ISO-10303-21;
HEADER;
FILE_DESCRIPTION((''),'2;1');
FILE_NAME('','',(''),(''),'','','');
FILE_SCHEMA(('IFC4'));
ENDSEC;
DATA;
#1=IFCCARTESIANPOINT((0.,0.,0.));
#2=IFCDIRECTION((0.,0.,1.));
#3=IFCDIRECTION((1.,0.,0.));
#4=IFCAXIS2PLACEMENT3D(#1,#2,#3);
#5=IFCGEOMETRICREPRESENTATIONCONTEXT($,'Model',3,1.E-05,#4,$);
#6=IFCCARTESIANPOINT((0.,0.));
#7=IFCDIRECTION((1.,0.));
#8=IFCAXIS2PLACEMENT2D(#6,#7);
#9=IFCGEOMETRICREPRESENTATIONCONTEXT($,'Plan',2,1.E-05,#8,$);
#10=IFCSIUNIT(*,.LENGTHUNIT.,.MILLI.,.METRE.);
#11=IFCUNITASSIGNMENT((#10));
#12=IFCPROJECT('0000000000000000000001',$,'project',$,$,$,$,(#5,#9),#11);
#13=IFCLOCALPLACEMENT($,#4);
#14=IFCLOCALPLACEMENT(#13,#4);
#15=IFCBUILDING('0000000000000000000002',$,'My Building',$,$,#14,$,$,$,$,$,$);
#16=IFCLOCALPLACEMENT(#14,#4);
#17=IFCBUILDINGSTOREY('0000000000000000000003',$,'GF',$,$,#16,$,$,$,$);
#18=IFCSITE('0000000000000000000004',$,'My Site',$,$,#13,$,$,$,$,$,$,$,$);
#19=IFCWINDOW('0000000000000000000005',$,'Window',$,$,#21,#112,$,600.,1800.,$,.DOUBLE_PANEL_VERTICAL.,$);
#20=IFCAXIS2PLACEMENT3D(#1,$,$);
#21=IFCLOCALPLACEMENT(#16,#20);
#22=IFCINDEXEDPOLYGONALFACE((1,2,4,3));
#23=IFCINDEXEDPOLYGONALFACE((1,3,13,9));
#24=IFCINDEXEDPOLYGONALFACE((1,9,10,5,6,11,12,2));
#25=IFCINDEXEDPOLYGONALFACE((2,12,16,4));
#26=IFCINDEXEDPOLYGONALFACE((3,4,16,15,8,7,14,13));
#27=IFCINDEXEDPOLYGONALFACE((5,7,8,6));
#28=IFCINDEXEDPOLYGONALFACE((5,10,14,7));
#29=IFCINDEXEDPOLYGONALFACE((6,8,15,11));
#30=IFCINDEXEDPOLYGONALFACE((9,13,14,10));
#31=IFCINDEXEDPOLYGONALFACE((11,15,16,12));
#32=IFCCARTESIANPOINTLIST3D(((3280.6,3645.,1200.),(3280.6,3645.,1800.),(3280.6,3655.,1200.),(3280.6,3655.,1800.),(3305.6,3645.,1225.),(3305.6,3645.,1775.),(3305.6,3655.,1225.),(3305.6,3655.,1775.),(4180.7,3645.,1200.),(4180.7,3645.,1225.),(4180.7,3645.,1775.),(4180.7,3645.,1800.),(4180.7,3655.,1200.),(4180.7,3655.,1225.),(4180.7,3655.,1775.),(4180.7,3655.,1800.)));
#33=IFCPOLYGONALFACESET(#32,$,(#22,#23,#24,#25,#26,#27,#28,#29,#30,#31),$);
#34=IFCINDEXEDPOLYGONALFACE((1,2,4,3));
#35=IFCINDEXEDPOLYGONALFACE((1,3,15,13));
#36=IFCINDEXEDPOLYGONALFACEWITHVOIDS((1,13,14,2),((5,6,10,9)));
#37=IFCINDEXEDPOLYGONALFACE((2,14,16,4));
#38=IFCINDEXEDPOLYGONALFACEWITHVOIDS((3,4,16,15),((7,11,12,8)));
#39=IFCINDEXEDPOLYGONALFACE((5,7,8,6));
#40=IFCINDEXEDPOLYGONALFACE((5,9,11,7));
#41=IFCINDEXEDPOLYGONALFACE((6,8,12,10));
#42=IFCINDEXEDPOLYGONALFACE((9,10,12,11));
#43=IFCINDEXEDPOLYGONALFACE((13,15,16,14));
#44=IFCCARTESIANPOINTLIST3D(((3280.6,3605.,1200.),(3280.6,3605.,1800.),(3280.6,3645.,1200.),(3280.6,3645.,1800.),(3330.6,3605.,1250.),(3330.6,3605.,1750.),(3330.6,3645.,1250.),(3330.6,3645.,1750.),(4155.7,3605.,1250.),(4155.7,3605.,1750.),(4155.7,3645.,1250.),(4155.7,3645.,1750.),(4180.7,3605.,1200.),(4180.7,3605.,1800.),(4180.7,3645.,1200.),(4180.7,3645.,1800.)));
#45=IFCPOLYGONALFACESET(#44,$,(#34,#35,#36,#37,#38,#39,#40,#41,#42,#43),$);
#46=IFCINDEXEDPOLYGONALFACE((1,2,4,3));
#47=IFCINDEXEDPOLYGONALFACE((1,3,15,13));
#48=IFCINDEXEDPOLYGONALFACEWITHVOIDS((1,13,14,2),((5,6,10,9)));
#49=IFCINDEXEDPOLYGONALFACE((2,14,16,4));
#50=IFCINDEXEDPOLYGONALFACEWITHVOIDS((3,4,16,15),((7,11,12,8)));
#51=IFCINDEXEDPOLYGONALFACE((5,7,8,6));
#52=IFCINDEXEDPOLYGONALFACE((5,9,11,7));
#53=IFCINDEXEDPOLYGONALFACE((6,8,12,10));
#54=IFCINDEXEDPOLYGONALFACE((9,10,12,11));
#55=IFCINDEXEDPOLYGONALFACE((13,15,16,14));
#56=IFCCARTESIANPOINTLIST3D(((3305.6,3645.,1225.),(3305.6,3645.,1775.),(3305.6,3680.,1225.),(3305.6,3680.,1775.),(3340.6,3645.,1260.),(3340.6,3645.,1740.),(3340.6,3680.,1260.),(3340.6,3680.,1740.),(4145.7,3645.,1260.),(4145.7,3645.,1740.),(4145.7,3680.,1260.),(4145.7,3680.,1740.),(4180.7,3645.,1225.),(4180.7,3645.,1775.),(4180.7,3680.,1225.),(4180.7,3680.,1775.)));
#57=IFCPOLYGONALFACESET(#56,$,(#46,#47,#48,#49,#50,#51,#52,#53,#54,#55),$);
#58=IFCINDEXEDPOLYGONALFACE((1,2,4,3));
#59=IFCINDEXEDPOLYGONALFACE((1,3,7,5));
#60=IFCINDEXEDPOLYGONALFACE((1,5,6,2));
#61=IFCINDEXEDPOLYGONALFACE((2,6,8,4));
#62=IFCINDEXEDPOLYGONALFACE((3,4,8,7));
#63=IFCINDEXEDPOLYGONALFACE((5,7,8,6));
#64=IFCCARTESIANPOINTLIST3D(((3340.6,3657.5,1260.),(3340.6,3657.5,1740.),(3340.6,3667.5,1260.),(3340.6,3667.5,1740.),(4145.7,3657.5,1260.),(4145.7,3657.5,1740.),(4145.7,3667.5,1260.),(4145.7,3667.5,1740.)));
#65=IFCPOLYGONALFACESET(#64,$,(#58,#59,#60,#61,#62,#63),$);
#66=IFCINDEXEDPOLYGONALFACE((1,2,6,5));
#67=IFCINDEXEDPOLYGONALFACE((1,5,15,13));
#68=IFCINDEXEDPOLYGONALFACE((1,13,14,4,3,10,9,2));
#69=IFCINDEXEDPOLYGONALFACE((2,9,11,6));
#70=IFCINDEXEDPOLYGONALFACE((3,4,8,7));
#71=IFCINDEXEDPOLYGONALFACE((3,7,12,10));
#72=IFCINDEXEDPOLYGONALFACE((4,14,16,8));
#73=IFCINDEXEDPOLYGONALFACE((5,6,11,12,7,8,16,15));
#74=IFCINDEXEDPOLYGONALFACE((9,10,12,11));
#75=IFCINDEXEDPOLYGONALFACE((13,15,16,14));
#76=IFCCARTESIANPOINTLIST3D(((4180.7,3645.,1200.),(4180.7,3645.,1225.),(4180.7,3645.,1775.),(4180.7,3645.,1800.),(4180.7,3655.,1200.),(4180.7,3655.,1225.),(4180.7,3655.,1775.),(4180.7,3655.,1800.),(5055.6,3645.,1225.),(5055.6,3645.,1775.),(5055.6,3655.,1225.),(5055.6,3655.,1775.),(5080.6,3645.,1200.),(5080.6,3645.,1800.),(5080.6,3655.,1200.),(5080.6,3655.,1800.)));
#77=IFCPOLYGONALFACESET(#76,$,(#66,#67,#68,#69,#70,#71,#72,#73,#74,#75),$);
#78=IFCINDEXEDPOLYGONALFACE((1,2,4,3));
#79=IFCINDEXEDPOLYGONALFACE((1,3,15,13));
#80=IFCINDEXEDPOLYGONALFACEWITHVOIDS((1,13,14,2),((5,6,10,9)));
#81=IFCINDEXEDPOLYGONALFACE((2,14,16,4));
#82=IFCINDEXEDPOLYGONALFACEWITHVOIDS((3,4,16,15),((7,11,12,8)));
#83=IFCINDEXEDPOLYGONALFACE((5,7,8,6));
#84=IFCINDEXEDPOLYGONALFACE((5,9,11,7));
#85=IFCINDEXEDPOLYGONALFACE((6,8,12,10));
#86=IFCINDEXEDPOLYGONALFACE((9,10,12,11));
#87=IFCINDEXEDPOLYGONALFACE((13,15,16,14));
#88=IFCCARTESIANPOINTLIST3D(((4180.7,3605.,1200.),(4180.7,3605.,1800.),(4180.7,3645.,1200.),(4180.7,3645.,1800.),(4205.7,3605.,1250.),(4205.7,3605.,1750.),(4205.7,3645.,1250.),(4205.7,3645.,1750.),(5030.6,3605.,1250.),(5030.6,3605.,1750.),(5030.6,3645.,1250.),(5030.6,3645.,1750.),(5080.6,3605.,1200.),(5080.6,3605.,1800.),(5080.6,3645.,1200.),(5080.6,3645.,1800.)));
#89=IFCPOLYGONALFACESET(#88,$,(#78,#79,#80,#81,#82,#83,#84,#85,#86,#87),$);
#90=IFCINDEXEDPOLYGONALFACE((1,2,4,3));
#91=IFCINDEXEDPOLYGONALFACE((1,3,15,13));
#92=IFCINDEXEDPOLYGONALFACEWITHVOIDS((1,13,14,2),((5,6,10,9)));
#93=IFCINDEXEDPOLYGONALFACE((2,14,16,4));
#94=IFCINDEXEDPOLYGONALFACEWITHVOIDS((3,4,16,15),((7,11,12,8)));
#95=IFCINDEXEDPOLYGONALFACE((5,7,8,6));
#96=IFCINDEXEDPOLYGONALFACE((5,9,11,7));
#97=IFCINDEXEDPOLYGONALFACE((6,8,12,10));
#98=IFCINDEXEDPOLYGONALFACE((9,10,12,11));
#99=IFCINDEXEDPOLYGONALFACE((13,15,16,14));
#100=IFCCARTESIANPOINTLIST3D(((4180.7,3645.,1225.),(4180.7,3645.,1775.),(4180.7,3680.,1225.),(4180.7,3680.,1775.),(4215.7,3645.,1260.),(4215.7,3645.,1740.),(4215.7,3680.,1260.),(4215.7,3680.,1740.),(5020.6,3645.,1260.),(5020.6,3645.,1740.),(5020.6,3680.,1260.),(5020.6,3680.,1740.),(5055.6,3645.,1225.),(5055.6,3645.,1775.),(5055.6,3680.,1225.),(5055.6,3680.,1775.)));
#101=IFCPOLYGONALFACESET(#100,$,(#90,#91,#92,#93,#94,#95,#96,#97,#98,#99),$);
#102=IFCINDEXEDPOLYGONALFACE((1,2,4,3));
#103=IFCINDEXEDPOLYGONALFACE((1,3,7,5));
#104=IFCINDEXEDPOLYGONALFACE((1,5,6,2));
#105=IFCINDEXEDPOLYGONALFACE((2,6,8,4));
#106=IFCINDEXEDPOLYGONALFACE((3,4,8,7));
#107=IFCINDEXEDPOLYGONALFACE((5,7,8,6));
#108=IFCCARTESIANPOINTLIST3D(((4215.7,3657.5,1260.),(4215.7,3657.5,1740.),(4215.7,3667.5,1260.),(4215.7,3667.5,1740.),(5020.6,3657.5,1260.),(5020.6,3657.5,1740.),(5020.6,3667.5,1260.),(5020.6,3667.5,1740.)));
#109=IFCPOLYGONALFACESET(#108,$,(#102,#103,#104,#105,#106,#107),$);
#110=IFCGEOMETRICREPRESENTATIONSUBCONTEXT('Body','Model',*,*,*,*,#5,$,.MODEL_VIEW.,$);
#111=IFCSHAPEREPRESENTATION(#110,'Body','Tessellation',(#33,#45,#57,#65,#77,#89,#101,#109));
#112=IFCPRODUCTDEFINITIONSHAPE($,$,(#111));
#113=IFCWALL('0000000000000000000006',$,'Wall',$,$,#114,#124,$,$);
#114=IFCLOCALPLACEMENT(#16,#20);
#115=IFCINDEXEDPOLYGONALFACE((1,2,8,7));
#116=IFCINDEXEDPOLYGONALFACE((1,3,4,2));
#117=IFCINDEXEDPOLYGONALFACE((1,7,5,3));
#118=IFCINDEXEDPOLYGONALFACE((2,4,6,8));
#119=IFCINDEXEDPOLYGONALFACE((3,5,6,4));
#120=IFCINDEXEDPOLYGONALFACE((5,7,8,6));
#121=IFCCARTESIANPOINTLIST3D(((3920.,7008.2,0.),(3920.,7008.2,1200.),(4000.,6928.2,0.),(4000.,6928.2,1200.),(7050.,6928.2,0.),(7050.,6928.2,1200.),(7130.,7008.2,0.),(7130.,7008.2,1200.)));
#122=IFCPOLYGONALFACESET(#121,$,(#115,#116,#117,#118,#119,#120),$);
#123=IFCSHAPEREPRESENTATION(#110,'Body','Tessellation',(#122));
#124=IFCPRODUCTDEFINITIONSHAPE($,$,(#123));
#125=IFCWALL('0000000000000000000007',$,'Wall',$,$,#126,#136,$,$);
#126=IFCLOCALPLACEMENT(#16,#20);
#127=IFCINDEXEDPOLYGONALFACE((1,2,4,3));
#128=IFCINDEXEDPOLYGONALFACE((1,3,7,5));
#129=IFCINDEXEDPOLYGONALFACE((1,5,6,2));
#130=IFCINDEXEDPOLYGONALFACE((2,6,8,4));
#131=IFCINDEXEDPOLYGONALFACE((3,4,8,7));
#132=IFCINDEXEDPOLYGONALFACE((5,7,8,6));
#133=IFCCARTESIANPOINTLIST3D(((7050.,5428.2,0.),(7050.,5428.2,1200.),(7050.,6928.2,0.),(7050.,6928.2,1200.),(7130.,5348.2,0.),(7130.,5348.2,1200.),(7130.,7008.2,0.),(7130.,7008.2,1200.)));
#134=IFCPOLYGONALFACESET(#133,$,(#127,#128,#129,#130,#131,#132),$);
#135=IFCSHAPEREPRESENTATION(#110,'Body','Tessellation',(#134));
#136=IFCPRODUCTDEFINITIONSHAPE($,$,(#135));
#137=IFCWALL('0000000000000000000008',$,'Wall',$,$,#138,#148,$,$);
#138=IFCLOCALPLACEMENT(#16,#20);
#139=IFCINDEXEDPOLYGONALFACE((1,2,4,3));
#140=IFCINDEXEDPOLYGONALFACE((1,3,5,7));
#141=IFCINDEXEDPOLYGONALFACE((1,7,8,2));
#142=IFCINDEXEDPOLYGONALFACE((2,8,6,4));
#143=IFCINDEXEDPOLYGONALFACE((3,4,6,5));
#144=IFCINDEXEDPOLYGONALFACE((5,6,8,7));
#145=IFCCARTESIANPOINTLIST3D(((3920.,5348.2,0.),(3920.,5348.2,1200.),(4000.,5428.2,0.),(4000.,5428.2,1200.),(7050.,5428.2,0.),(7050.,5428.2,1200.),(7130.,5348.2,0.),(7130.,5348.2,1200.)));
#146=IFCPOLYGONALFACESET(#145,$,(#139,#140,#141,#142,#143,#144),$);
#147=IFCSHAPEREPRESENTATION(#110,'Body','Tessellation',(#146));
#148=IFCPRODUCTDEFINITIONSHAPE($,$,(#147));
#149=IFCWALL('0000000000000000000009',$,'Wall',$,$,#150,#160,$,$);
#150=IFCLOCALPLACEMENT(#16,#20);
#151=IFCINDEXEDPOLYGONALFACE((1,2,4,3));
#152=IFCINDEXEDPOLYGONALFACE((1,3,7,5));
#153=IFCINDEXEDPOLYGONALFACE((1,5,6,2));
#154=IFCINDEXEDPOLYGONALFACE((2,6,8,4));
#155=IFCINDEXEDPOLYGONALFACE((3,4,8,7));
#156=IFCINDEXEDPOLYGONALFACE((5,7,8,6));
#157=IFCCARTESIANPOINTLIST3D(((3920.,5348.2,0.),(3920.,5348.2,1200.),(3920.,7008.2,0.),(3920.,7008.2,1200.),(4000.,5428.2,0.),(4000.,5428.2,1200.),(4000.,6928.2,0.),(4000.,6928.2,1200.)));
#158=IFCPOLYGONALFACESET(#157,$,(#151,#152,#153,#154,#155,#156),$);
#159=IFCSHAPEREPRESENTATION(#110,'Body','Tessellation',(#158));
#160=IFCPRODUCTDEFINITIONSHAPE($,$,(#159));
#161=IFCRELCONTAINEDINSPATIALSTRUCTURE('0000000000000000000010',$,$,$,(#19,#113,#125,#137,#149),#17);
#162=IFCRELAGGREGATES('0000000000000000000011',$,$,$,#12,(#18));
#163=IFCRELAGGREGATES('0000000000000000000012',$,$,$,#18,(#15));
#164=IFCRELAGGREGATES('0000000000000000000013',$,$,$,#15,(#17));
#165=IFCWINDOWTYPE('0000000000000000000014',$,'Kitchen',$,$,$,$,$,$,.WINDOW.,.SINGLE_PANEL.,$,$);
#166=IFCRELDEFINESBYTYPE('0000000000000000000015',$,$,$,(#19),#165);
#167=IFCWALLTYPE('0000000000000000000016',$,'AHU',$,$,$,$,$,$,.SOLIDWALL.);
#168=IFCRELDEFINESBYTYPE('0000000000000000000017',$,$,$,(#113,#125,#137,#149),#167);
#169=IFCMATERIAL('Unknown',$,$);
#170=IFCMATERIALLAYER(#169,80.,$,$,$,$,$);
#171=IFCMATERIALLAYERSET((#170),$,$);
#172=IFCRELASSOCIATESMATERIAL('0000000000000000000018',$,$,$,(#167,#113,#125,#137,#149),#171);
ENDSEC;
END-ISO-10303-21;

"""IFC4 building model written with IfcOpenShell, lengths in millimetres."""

from ifc_helpers import new_model, entity, si_unit, frame, origin_with_axes, origin_2d_with_axis, place, context, subcontext, project, spatial, line, indexed_curve, outline, extrude, shape, source, transform, mapped, material, layer, layer_set, layer_usage, type_object, type_shapes, element, save


model = new_model("IFC4")

# Units and contexts
model_context = context("Model", 3, precision=1e-05, world=origin_with_axes())
plan_context = context("Plan", 2, precision=1e-05, world=origin_2d_with_axis())
body_context_1 = subcontext(model_context, "Body", "Model", "MODEL_VIEW")
body_context_2 = subcontext(plan_context, "Body", "Plan", "PLAN_VIEW")
ifc_project = project(units=[si_unit("LENGTHUNIT", "METRE", prefix="MILLI")], contexts=[model_context, plan_context])

# Site, building, storey
site_placement = place(None, origin_with_axes())
site = spatial("IfcSite", under=ifc_project, at=site_placement, Name="My Site")
building_placement = place(site_placement, origin_with_axes())
building = spatial("IfcBuilding", under=site, at=building_placement, Name="My Building")
storey_placement = place(building_placement, origin_with_axes())
storey = spatial("IfcBuildingStorey", under=building, at=storey_placement, Name="GF")

# Shared definitions
ifc_material = material(Name="Unknown")

# Window
window_type_1 = type_object("IfcWindowType", Name="Kitchen", PartitioningType="SINGLE_PANEL", PredefinedType="WINDOW")
shared_shape_1 = source(origin_with_axes(), body_context_1, "Body", "SweptSolid", [
    extrude(outline(indexed_curve([(900.2, 0.0), (0.0, 0.0), (0.0, 600.0), (900.2, 600.0), (900.2, 575.0), (25.0, 575.0), (25.0, 25.0), (900.2, 25.0)], segments=[line(1, 2, 3, 4, 5, 6, 7, 8, 1)])), frame((0.0, 90.0, 0.0), z_axis=(0.0, -1.0, 0.0), x_axis=(1.0, 0.0, 0.0)), (0.0, 0.0, -1.0), 10.0),
    extrude(outline(indexed_curve([(0.0, 0.0), (900.2, 0.0), (900.2, 600.0), (0.0, 600.0)], segments=[line(1, 2, 3, 4, 1)]), holes=[indexed_curve([(50.0, 50.0), (875.2, 50.0), (875.2, 550.0), (50.0, 550.0)], segments=[line(1, 2, 3, 4, 1)])]), frame((0.0, 50.0, 0.0), z_axis=(0.0, -1.0, 0.0), x_axis=(1.0, 0.0, 0.0)), (0.0, 0.0, -1.0), 40.0),
    extrude(outline(indexed_curve([(0.0, 0.0), (875.2, 0.0), (875.2, 550.0), (0.0, 550.0)], segments=[line(1, 2, 3, 4, 1)]), holes=[indexed_curve([(35.0, 35.0), (840.2, 35.0), (840.2, 515.0), (35.0, 515.0)], segments=[line(1, 2, 3, 4, 1)])]), frame((25.0, 90.0, 25.0), z_axis=(0.0, -1.0, 0.0), x_axis=(1.0, 0.0, 0.0)), (0.0, 0.0, -1.0), 35.0),
    extrude(outline(indexed_curve([(35.0, 35.0), (840.2, 35.0), (840.2, 515.0), (35.0, 515.0)], segments=[line(1, 2, 3, 4, 1)])), frame((25.0, 102.5, 25.0), z_axis=(0.0, -1.0, 0.0), x_axis=(1.0, 0.0, 0.0)), (0.0, 0.0, -1.0), 10.0),
    extrude(outline(indexed_curve([(0.0, 600.0), (899.8, 600.0), (899.8, 0.0), (0.0, 0.0), (0.0, 25.0), (874.8, 25.0), (874.8, 575.0), (0.0, 575.0)], segments=[line(1, 2, 3, 4, 5, 6, 7, 8, 1)])), frame((900.2, 90.0, 0.0), z_axis=(0.0, -1.0, 0.0), x_axis=(1.0, 0.0, 0.0)), (0.0, 0.0, -1.0), 10.0),
    extrude(outline(indexed_curve([(0.0, 0.0), (899.8, 0.0), (899.8, 600.0), (0.0, 600.0)], segments=[line(1, 2, 3, 4, 1)]), holes=[indexed_curve([(25.0, 50.0), (849.8, 50.0), (849.8, 550.0), (25.0, 550.0)], segments=[line(1, 2, 3, 4, 1)])]), frame((900.2, 50.0, 0.0), z_axis=(0.0, -1.0, 0.0), x_axis=(1.0, 0.0, 0.0)), (0.0, 0.0, -1.0), 40.0),
    extrude(outline(indexed_curve([(0.0, 0.0), (874.8, 0.0), (874.8, 550.0), (0.0, 550.0)], segments=[line(1, 2, 3, 4, 1)]), holes=[indexed_curve([(35.0, 35.0), (839.8, 35.0), (839.8, 515.0), (35.0, 515.0)], segments=[line(1, 2, 3, 4, 1)])]), frame((900.2, 90.0, 25.0), z_axis=(0.0, -1.0, 0.0), x_axis=(1.0, 0.0, 0.0)), (0.0, 0.0, -1.0), 35.0),
    extrude(outline(indexed_curve([(35.0, 35.0), (839.8, 35.0), (839.8, 515.0), (35.0, 515.0)], segments=[line(1, 2, 3, 4, 1)])), frame((900.2, 102.5, 25.0), z_axis=(0.0, -1.0, 0.0), x_axis=(1.0, 0.0, 0.0)), (0.0, 0.0, -1.0), 10.0),
])
shared_shape_2 = source(origin_with_axes(), body_context_2, "Body", "Curve2D", [
    entity("IfcIndexedPolyCurve", entity("IfcCartesianPointList2D", [[50.0, 50.0], [875.2, 50.0]])),
    entity("IfcIndexedPolyCurve", entity("IfcCartesianPointList2D", [[0.0, 100.0], [25.0, 100.0], [25.0, 90.0], [50.0, 90.0], [50.0, 50.0], [0.0, 50.0]]), [entity("IfcLineIndex", [1, 2, 3, 4, 5, 6, 1])]),
    entity("IfcIndexedPolyCurve", entity("IfcCartesianPointList2D", [[900.2, 100.0], [900.2, 100.0], [900.2, 90.0], [875.2, 90.0], [875.2, 50.0], [900.2, 50.0]])),
    entity("IfcIndexedPolyCurve", entity("IfcCartesianPointList2D", [[25.0, 90.0], [60.0, 90.0], [60.0, 125.0], [25.0, 125.0]]), [entity("IfcLineIndex", [1, 2, 3, 4, 1])]),
    entity("IfcIndexedPolyCurve", entity("IfcCartesianPointList2D", [[900.2, 90.0], [865.2, 90.0], [865.2, 125.0], [900.2, 125.0]]), [entity("IfcLineIndex", [1, 2, 3, 4, 1])]),
    entity("IfcIndexedPolyCurve", entity("IfcCartesianPointList2D", [[60.0, 90.0], [865.2, 90.0]])),
    entity("IfcIndexedPolyCurve", entity("IfcCartesianPointList2D", [[60.0, 125.0], [865.2, 125.0]])),
    entity("IfcIndexedPolyCurve", entity("IfcCartesianPointList2D", [[60.0, 107.5], [865.2, 107.5]])),
    entity("IfcIndexedPolyCurve", entity("IfcCartesianPointList2D", [[925.2, 50.0], [1750.0, 50.0]])),
    entity("IfcIndexedPolyCurve", entity("IfcCartesianPointList2D", [[900.2, 100.0], [900.2, 100.0], [900.2, 90.0], [925.2, 90.0], [925.2, 50.0], [900.2, 50.0]])),
    entity("IfcIndexedPolyCurve", entity("IfcCartesianPointList2D", [[1800.0, 100.0], [1775.0, 100.0], [1775.0, 90.0], [1750.0, 90.0], [1750.0, 50.0], [1800.0, 50.0]]), [entity("IfcLineIndex", [1, 2, 3, 4, 5, 6, 1])]),
    entity("IfcIndexedPolyCurve", entity("IfcCartesianPointList2D", [[900.2, 90.0], [935.2, 90.0], [935.2, 125.0], [900.2, 125.0]]), [entity("IfcLineIndex", [1, 2, 3, 4, 1])]),
    entity("IfcIndexedPolyCurve", entity("IfcCartesianPointList2D", [[1775.0, 90.0], [1740.0, 90.0], [1740.0, 125.0], [1775.0, 125.0]]), [entity("IfcLineIndex", [1, 2, 3, 4, 1])]),
    entity("IfcIndexedPolyCurve", entity("IfcCartesianPointList2D", [[935.2, 90.0], [1740.0, 90.0]])),
    entity("IfcIndexedPolyCurve", entity("IfcCartesianPointList2D", [[935.2, 125.0], [1740.0, 125.0]])),
    entity("IfcIndexedPolyCurve", entity("IfcCartesianPointList2D", [[935.2, 107.5], [1740.0, 107.5]])),
])
type_shapes(window_type_1, [shared_shape_1, shared_shape_2])
window_1_placement = place(storey_placement, frame((3280.6, 3555.0, 1200.0), z_axis=(0.0, 0.0, 1.0), x_axis=(1.0, 0.0, 0.0)))
element("IfcWindow", 1, at=window_1_placement, inside=storey, type_object=window_type_1, Name="Window", OverallHeight=600.0, OverallWidth=1800.0, PartitioningType="DOUBLE_PANEL_VERTICAL", shapes=[
    shape(body_context_1, "Body", "MappedRepresentation", [mapped(shared_shape_1, transform((0.0, 0.0, 0.0), x_axis=(1.0, 0.0, 0.0), y_axis=(0.0, 1.0, 0.0), z_axis=(0.0, 0.0, 1.0), scale=1.0))]),
    shape(body_context_2, "Body", "MappedRepresentation", [mapped(shared_shape_2, transform((0.0, 0.0, 0.0), x_axis=(1.0, 0.0, 0.0), y_axis=(0.0, 1.0, 0.0), z_axis=(0.0, 0.0, 1.0), scale=1.0))]),
])

# Walls
ifc_layer_1 = layer(ifc_material, 80.0)
ifc_layer_set_1 = layer_set([ifc_layer_1])
ifc_layer_usage_1 = layer_usage(ifc_layer_set_1, "AXIS2", "POSITIVE", 0.0)
wall_type_1 = type_object("IfcWallType", Name="AHU", PredefinedType="SOLIDWALL", material=ifc_layer_set_1)
wall_1_placement = place(storey_placement, frame((4000.0, 6928.2, 0.0), z_axis=(0.0, 0.0, 1.0), x_axis=(1.0, 0.0, 0.0)))
element("IfcWall", 2, at=wall_1_placement, inside=storey, type_object=wall_type_1, material=ifc_layer_usage_1, Name="Wall", context=body_context_1, shape_type="SweptSolid", body=[
    extrude(outline(indexed_curve([(0.0, 0.0), (-80.0, 80.0), (3130.0, 80.0), (3050.0, 0.0)], segments=[line(1, 2, 3, 4, 1)])), origin_with_axes(), (0.0, 0.0, 1.0), 1200.0),
])
ifc_layer_usage_2 = layer_usage(ifc_layer_set_1, "AXIS2", "POSITIVE", 0.0)
wall_2_placement = place(storey_placement, frame((7050.0, 6928.2, 0.0), z_axis=(0.0, 0.0, 1.0), x_axis=(0.0, -1.0, 0.0)))
element("IfcWall", 3, at=wall_2_placement, inside=storey, type_object=wall_type_1, material=ifc_layer_usage_2, Name="Wall", context=body_context_1, shape_type="SweptSolid", body=[
    extrude(outline(indexed_curve([(0.0, 0.0), (-80.0, 80.0), (1580.0, 80.0), (1500.0, 0.0)], segments=[line(1, 2, 3, 4, 1)])), origin_with_axes(), (0.0, 0.0, 1.0), 1200.0),
])
ifc_layer_usage_3 = layer_usage(ifc_layer_set_1, "AXIS2", "POSITIVE", 0.0)
wall_3_placement = place(storey_placement, frame((7050.0, 5428.2, 0.0), z_axis=(0.0, 0.0, 1.0), x_axis=(-1.0, 0.0, 0.0)))
element("IfcWall", 4, at=wall_3_placement, inside=storey, type_object=wall_type_1, material=ifc_layer_usage_3, Name="Wall", context=body_context_1, shape_type="SweptSolid", body=[
    extrude(outline(indexed_curve([(0.0, 0.0), (-80.0, 80.0), (3130.0, 80.0), (3050.0, 0.0)], segments=[line(1, 2, 3, 4, 1)])), origin_with_axes(), (0.0, 0.0, 1.0), 1200.0),
])
ifc_layer_usage_4 = layer_usage(ifc_layer_set_1, "AXIS2", "POSITIVE", 0.0)
wall_4_placement = place(storey_placement, frame((4000.0, 5428.2, 0.0), z_axis=(0.0, 0.0, 1.0), x_axis=(0.0, 1.0, 0.0)))
element("IfcWall", 5, at=wall_4_placement, inside=storey, type_object=wall_type_1, material=ifc_layer_usage_4, Name="Wall", context=body_context_1, shape_type="SweptSolid", body=[
    extrude(outline(indexed_curve([(0.0, 0.0), (-80.0, 80.0), (1580.0, 80.0), (1500.0, 0.0)], segments=[line(1, 2, 3, 4, 1)])), origin_with_axes(), (0.0, 0.0, 1.0), 1200.0),
])

save(model, "model.ifc")
